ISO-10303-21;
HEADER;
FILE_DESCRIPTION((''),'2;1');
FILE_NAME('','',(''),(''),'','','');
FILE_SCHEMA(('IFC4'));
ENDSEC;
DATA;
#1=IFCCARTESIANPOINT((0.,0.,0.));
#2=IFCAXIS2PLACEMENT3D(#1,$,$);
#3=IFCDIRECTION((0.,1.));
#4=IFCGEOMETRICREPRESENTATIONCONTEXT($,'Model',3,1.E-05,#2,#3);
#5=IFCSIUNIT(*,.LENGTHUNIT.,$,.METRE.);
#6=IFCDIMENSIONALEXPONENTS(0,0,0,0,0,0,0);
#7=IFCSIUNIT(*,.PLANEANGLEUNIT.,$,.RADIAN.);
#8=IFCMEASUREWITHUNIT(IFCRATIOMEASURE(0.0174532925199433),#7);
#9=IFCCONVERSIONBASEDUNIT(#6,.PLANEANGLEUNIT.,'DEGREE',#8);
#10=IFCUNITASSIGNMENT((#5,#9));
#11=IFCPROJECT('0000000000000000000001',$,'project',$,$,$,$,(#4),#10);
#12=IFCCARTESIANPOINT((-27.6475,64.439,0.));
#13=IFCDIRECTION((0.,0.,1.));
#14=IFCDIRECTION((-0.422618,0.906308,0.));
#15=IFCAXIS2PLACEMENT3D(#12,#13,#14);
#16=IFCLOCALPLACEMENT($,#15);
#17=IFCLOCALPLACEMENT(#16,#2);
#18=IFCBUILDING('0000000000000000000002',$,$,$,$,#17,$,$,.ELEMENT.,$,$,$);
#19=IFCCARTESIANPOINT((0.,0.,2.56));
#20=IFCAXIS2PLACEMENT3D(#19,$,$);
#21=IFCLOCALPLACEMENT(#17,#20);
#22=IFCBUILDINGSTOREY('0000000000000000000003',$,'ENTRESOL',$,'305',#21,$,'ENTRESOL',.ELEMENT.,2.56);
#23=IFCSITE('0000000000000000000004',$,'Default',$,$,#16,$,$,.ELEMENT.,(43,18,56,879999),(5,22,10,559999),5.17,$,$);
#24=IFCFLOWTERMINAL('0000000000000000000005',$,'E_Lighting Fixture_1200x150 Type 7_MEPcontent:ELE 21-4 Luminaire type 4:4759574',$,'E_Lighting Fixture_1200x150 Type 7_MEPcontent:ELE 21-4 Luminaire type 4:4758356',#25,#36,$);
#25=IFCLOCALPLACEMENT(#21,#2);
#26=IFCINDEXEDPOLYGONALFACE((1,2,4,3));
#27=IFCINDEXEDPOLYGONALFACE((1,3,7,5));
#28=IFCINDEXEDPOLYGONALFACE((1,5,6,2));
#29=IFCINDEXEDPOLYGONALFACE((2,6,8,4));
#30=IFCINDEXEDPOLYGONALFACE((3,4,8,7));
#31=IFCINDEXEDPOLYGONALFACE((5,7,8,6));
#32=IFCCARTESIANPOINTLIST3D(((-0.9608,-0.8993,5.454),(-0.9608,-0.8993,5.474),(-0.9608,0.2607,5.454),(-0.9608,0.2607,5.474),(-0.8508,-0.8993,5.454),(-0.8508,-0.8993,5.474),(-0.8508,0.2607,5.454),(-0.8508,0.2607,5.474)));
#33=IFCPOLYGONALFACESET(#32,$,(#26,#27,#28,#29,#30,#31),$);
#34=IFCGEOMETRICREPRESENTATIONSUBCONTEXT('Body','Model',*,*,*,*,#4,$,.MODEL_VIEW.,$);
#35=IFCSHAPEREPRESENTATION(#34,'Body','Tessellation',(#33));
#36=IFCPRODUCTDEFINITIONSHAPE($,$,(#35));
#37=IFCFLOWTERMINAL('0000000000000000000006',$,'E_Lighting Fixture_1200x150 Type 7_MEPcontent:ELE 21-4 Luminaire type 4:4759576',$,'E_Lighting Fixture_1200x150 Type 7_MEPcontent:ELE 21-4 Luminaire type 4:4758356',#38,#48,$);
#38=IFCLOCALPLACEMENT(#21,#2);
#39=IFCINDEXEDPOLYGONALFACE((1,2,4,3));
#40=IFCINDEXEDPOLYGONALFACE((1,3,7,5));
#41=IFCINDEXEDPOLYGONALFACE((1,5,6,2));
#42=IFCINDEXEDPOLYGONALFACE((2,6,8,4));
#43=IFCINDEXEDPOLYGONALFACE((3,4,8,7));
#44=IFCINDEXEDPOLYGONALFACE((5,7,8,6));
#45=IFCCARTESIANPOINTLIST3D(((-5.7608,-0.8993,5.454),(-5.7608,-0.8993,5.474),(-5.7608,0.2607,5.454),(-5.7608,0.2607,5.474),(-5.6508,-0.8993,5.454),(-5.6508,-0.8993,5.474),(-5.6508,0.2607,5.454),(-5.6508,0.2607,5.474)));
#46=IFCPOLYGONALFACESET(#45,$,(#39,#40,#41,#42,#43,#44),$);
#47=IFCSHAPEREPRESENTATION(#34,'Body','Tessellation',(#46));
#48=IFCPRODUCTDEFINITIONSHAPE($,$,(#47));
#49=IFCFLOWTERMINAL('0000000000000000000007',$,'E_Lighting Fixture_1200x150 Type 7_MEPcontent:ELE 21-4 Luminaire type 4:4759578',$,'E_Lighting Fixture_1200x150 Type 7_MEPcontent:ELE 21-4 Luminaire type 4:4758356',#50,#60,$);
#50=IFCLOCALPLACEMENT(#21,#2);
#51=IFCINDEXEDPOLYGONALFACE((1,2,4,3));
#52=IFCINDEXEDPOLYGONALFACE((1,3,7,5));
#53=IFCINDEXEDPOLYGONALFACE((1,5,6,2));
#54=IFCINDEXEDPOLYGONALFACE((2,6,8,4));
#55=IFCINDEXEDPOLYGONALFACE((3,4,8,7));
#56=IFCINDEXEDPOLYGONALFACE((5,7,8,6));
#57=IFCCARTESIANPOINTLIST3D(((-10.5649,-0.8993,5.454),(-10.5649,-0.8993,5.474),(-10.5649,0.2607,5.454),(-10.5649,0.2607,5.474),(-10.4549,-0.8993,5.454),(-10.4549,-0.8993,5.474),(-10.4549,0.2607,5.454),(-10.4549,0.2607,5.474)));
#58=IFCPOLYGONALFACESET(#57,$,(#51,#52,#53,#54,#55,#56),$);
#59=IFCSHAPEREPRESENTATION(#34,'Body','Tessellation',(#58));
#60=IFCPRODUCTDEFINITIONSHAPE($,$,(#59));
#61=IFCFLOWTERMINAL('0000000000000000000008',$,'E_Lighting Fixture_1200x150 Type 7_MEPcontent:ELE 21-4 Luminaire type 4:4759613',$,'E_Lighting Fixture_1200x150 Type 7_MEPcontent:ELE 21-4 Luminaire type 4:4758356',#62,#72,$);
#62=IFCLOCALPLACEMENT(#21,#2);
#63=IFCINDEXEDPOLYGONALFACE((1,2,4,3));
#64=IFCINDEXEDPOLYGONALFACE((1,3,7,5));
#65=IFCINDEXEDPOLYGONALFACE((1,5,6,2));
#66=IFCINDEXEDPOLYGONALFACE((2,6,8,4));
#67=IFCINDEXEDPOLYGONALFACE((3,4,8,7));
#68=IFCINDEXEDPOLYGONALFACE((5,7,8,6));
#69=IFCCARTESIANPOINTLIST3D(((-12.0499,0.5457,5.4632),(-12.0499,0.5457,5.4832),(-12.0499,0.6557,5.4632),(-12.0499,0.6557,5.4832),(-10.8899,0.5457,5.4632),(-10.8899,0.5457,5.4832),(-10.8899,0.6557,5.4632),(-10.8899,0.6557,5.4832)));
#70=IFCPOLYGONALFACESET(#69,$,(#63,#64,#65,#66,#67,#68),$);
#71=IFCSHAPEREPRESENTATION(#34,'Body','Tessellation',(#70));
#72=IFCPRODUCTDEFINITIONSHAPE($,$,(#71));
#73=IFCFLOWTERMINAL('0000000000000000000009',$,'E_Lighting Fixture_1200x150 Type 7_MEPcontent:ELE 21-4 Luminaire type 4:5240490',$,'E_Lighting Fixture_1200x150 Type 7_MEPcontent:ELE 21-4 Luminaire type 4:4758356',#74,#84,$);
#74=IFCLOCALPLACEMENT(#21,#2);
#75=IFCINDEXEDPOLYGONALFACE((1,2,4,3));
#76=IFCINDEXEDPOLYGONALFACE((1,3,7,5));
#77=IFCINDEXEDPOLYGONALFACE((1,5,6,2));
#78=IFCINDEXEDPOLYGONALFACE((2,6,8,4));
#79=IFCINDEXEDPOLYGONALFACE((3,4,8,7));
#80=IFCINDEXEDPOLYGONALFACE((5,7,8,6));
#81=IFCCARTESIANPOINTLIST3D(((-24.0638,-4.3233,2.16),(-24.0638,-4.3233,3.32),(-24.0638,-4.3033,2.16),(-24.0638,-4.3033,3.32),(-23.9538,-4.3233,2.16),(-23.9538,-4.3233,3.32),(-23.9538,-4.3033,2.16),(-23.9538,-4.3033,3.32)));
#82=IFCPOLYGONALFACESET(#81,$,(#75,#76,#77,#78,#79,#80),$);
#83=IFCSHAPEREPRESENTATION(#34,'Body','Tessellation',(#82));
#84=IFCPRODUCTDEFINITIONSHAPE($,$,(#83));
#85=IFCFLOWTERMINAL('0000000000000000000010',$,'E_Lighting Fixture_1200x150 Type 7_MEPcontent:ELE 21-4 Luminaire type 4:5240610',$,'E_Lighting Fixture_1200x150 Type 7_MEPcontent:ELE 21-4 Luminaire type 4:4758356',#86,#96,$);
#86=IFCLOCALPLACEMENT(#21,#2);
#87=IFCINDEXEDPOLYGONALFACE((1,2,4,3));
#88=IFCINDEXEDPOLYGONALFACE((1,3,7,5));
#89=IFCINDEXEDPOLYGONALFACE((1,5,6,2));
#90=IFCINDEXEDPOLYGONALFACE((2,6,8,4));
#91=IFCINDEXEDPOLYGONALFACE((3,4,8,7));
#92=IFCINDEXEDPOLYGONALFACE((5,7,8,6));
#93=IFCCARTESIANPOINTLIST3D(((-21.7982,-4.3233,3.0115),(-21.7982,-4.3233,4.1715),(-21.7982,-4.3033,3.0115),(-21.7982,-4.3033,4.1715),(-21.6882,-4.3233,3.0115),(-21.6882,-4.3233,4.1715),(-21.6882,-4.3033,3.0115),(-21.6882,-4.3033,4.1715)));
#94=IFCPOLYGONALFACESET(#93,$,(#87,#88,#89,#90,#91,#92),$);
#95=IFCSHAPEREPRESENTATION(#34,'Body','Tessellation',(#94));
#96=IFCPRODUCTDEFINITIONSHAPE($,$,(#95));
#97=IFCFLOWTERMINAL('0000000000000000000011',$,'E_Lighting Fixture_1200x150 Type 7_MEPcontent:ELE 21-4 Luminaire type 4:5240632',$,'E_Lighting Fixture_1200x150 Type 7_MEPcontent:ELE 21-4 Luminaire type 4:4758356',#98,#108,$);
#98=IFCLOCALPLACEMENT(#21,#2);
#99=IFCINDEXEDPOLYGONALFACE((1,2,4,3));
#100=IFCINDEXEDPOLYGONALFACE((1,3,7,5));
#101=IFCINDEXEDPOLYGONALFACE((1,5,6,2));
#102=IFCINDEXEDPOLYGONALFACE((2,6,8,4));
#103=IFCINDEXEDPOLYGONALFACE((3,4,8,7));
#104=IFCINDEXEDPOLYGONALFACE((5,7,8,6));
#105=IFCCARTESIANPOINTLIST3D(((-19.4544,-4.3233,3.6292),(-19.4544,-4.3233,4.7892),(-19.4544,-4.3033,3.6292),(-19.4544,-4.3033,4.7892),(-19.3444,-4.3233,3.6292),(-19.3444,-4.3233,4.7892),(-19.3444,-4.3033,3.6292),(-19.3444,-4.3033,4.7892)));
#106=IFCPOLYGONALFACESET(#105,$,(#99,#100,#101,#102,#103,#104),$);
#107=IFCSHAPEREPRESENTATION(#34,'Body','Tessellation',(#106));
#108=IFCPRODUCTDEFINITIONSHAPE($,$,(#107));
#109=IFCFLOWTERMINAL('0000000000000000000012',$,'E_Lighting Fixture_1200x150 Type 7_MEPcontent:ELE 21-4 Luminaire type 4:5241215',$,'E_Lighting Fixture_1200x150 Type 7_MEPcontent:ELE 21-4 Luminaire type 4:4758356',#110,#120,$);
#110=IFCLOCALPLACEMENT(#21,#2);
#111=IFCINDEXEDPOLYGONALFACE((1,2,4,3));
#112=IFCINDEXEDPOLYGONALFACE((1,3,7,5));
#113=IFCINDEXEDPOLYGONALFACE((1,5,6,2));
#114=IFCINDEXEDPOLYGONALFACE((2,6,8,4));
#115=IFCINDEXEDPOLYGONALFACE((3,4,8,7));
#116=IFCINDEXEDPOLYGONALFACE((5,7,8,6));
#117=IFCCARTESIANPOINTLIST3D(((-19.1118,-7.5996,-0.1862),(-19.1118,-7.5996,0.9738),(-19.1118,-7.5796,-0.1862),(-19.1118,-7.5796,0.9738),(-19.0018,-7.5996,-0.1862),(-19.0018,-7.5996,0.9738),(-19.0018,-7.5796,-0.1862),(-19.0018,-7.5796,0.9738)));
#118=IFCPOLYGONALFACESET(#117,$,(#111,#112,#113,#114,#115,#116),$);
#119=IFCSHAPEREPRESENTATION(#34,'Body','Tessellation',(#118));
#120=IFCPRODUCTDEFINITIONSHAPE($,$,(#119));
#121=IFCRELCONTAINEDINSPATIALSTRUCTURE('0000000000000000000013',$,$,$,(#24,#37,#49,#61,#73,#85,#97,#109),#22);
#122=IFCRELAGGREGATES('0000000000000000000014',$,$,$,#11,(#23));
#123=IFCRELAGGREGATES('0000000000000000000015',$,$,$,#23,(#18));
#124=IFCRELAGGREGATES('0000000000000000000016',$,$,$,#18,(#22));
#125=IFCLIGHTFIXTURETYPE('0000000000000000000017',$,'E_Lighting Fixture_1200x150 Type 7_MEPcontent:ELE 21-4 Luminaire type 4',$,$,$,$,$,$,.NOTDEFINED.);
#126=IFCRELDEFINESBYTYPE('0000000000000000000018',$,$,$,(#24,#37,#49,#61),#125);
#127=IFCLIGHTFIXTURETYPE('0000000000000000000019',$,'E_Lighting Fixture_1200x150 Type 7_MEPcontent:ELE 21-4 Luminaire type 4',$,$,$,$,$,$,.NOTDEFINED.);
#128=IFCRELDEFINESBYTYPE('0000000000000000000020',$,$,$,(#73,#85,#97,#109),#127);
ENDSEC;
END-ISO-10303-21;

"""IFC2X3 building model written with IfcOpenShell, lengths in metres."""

from ifc_helpers import new_model, entity, si_unit, converted_unit, direction, frame, frame_2d, origin, origin_2d_with_axis, place, context, subcontext, project, spatial, rectangle, extrude, source, transform, mapped, type_object, type_shapes, element, save


model = new_model("IFC2X3")

# Units and contexts
model_context = context("Model", 3, precision=1e-05, world=origin(), true_north=direction((0.0, 1.0)))
body_context = subcontext(model_context, "Body", "Model", "MODEL_VIEW")
ifc_project = project(units=[si_unit("LENGTHUNIT", "METRE"), converted_unit("PLANEANGLEUNIT", "DEGREE", entity("IfcRatioMeasure", 0.0174532925199433), si_unit("PLANEANGLEUNIT", "RADIAN"), dimensions=[0, 0, 0, 0, 0, 0, 0])], contexts=[model_context])

# Site, building, storey
site_placement = place(None, frame((-27.6475, 64.439, 0.0), z_axis=(0.0, 0.0, 1.0), x_axis=(-0.422618, 0.906308, 0.0)))
site = spatial("IfcSite", under=ifc_project, at=site_placement, Name="Default", CompositionType="ELEMENT", RefLatitude=(43, 18, 56, 879999), RefLongitude=(5, 22, 10, 559999), RefElevation=5.17)
building_placement = place(site_placement, origin())
building = spatial("IfcBuilding", under=site, at=building_placement, CompositionType="ELEMENT")
storey_placement = place(building_placement, frame((0.0, 0.0, 2.56)))
storey = spatial("IfcBuildingStorey", under=building, at=storey_placement, Name="ENTRESOL", ObjectType="305", LongName="ENTRESOL", CompositionType="ELEMENT", Elevation=2.56)

# Flow terminals
light_fixture_type_1 = type_object("IfcLightFixtureType", Name="E_Lighting Fixture_1200x150 Type 7_MEPcontent:ELE 21-4 Luminaire type 4", PredefinedType="NOTDEFINED")
shared_shape_1 = source(origin(), body_context, "Body", "SweptSolid", [
    extrude(rectangle(XDim=0.11, YDim=1.16, at=origin_2d_with_axis()), frame((0.0, 0.0, 0.0), z_axis=(0.0, 0.0, 1.0), x_axis=(0.0, -1.0, 0.0)), (0.0, 0.0, 1.0), 0.02),
])
type_shapes(light_fixture_type_1, [shared_shape_1])
for number, where, z_axis, x_axis, name in (
    (1, (-0.9058, -0.3193, 5.454), (0.0, 0.0, 1.0), (0.0, -1.0, 0.0), "E_Lighting Fixture_1200x150 Type 7_MEPcontent:ELE 21-4 Luminaire type 4:4759574"),
    (2, (-5.7058, -0.3193, 5.454), (0.0, 0.0, 1.0), (0.0, -1.0, 0.0), "E_Lighting Fixture_1200x150 Type 7_MEPcontent:ELE 21-4 Luminaire type 4:4759576"),
    (3, (-10.5099, -0.3193, 5.454), (0.0, 0.0, 1.0), (0.0, -1.0, 0.0), "E_Lighting Fixture_1200x150 Type 7_MEPcontent:ELE 21-4 Luminaire type 4:4759578"),
):
    element("IfcFlowTerminal", number, at=place(storey_placement, frame(where, z_axis=z_axis, x_axis=x_axis)), inside=storey, type_object=light_fixture_type_1, Name=name, ObjectType="E_Lighting Fixture_1200x150 Type 7_MEPcontent:ELE 21-4 Luminaire type 4:4758356", context=body_context, shape_type="MappedRepresentation", body=[
        mapped(shared_shape_1, transform((0.0, 0.0, 0.0), scale=1.0)),
    ])
flow_terminal_placement = place(storey_placement, frame((-11.4699, 0.6007, 5.4632)))
element("IfcFlowTerminal", 4, at=flow_terminal_placement, inside=storey, type_object=light_fixture_type_1, Name="E_Lighting Fixture_1200x150 Type 7_MEPcontent:ELE 21-4 Luminaire type 4:4759613", ObjectType="E_Lighting Fixture_1200x150 Type 7_MEPcontent:ELE 21-4 Luminaire type 4:4758356", context=body_context, shape_type="MappedRepresentation", body=[
    mapped(shared_shape_1, transform((0.0, 0.0, 0.0), scale=1.0)),
])
light_fixture_type_2 = type_object("IfcLightFixtureType", Name="E_Lighting Fixture_1200x150 Type 7_MEPcontent:ELE 21-4 Luminaire type 4", PredefinedType="NOTDEFINED")
shared_shape_2 = source(origin(), body_context, "Body", "SweptSolid", [
    extrude(rectangle(XDim=0.02, YDim=0.11, at=frame_2d((0.0, 0.0), x_axis=(1.0, 0.0))), frame((0.0, 0.01, -0.58), z_axis=(0.0, 0.0, 1.0), x_axis=(0.0, -1.0, 0.0)), (0.0, 0.0, 1.0), 1.16),
])
type_shapes(light_fixture_type_2, [shared_shape_2])
for number, where, name in (
    (5, (-24.0088, -4.3233, 2.74), "E_Lighting Fixture_1200x150 Type 7_MEPcontent:ELE 21-4 Luminaire type 4:5240490"),
    (6, (-21.7432, -4.3233, 3.5915), "E_Lighting Fixture_1200x150 Type 7_MEPcontent:ELE 21-4 Luminaire type 4:5240610"),
    (7, (-19.3994, -4.3233, 4.2092), "E_Lighting Fixture_1200x150 Type 7_MEPcontent:ELE 21-4 Luminaire type 4:5240632"),
    (8, (-19.0568, -7.5996, 0.3938), "E_Lighting Fixture_1200x150 Type 7_MEPcontent:ELE 21-4 Luminaire type 4:5241215"),
):
    element("IfcFlowTerminal", number, at=place(storey_placement, frame(where)), inside=storey, type_object=light_fixture_type_2, Name=name, ObjectType="E_Lighting Fixture_1200x150 Type 7_MEPcontent:ELE 21-4 Luminaire type 4:4758356", context=body_context, shape_type="MappedRepresentation", body=[
        mapped(shared_shape_2, transform((0.0, 0.0, 0.0), scale=1.0)),
    ])

save(model, "model.ifc")
